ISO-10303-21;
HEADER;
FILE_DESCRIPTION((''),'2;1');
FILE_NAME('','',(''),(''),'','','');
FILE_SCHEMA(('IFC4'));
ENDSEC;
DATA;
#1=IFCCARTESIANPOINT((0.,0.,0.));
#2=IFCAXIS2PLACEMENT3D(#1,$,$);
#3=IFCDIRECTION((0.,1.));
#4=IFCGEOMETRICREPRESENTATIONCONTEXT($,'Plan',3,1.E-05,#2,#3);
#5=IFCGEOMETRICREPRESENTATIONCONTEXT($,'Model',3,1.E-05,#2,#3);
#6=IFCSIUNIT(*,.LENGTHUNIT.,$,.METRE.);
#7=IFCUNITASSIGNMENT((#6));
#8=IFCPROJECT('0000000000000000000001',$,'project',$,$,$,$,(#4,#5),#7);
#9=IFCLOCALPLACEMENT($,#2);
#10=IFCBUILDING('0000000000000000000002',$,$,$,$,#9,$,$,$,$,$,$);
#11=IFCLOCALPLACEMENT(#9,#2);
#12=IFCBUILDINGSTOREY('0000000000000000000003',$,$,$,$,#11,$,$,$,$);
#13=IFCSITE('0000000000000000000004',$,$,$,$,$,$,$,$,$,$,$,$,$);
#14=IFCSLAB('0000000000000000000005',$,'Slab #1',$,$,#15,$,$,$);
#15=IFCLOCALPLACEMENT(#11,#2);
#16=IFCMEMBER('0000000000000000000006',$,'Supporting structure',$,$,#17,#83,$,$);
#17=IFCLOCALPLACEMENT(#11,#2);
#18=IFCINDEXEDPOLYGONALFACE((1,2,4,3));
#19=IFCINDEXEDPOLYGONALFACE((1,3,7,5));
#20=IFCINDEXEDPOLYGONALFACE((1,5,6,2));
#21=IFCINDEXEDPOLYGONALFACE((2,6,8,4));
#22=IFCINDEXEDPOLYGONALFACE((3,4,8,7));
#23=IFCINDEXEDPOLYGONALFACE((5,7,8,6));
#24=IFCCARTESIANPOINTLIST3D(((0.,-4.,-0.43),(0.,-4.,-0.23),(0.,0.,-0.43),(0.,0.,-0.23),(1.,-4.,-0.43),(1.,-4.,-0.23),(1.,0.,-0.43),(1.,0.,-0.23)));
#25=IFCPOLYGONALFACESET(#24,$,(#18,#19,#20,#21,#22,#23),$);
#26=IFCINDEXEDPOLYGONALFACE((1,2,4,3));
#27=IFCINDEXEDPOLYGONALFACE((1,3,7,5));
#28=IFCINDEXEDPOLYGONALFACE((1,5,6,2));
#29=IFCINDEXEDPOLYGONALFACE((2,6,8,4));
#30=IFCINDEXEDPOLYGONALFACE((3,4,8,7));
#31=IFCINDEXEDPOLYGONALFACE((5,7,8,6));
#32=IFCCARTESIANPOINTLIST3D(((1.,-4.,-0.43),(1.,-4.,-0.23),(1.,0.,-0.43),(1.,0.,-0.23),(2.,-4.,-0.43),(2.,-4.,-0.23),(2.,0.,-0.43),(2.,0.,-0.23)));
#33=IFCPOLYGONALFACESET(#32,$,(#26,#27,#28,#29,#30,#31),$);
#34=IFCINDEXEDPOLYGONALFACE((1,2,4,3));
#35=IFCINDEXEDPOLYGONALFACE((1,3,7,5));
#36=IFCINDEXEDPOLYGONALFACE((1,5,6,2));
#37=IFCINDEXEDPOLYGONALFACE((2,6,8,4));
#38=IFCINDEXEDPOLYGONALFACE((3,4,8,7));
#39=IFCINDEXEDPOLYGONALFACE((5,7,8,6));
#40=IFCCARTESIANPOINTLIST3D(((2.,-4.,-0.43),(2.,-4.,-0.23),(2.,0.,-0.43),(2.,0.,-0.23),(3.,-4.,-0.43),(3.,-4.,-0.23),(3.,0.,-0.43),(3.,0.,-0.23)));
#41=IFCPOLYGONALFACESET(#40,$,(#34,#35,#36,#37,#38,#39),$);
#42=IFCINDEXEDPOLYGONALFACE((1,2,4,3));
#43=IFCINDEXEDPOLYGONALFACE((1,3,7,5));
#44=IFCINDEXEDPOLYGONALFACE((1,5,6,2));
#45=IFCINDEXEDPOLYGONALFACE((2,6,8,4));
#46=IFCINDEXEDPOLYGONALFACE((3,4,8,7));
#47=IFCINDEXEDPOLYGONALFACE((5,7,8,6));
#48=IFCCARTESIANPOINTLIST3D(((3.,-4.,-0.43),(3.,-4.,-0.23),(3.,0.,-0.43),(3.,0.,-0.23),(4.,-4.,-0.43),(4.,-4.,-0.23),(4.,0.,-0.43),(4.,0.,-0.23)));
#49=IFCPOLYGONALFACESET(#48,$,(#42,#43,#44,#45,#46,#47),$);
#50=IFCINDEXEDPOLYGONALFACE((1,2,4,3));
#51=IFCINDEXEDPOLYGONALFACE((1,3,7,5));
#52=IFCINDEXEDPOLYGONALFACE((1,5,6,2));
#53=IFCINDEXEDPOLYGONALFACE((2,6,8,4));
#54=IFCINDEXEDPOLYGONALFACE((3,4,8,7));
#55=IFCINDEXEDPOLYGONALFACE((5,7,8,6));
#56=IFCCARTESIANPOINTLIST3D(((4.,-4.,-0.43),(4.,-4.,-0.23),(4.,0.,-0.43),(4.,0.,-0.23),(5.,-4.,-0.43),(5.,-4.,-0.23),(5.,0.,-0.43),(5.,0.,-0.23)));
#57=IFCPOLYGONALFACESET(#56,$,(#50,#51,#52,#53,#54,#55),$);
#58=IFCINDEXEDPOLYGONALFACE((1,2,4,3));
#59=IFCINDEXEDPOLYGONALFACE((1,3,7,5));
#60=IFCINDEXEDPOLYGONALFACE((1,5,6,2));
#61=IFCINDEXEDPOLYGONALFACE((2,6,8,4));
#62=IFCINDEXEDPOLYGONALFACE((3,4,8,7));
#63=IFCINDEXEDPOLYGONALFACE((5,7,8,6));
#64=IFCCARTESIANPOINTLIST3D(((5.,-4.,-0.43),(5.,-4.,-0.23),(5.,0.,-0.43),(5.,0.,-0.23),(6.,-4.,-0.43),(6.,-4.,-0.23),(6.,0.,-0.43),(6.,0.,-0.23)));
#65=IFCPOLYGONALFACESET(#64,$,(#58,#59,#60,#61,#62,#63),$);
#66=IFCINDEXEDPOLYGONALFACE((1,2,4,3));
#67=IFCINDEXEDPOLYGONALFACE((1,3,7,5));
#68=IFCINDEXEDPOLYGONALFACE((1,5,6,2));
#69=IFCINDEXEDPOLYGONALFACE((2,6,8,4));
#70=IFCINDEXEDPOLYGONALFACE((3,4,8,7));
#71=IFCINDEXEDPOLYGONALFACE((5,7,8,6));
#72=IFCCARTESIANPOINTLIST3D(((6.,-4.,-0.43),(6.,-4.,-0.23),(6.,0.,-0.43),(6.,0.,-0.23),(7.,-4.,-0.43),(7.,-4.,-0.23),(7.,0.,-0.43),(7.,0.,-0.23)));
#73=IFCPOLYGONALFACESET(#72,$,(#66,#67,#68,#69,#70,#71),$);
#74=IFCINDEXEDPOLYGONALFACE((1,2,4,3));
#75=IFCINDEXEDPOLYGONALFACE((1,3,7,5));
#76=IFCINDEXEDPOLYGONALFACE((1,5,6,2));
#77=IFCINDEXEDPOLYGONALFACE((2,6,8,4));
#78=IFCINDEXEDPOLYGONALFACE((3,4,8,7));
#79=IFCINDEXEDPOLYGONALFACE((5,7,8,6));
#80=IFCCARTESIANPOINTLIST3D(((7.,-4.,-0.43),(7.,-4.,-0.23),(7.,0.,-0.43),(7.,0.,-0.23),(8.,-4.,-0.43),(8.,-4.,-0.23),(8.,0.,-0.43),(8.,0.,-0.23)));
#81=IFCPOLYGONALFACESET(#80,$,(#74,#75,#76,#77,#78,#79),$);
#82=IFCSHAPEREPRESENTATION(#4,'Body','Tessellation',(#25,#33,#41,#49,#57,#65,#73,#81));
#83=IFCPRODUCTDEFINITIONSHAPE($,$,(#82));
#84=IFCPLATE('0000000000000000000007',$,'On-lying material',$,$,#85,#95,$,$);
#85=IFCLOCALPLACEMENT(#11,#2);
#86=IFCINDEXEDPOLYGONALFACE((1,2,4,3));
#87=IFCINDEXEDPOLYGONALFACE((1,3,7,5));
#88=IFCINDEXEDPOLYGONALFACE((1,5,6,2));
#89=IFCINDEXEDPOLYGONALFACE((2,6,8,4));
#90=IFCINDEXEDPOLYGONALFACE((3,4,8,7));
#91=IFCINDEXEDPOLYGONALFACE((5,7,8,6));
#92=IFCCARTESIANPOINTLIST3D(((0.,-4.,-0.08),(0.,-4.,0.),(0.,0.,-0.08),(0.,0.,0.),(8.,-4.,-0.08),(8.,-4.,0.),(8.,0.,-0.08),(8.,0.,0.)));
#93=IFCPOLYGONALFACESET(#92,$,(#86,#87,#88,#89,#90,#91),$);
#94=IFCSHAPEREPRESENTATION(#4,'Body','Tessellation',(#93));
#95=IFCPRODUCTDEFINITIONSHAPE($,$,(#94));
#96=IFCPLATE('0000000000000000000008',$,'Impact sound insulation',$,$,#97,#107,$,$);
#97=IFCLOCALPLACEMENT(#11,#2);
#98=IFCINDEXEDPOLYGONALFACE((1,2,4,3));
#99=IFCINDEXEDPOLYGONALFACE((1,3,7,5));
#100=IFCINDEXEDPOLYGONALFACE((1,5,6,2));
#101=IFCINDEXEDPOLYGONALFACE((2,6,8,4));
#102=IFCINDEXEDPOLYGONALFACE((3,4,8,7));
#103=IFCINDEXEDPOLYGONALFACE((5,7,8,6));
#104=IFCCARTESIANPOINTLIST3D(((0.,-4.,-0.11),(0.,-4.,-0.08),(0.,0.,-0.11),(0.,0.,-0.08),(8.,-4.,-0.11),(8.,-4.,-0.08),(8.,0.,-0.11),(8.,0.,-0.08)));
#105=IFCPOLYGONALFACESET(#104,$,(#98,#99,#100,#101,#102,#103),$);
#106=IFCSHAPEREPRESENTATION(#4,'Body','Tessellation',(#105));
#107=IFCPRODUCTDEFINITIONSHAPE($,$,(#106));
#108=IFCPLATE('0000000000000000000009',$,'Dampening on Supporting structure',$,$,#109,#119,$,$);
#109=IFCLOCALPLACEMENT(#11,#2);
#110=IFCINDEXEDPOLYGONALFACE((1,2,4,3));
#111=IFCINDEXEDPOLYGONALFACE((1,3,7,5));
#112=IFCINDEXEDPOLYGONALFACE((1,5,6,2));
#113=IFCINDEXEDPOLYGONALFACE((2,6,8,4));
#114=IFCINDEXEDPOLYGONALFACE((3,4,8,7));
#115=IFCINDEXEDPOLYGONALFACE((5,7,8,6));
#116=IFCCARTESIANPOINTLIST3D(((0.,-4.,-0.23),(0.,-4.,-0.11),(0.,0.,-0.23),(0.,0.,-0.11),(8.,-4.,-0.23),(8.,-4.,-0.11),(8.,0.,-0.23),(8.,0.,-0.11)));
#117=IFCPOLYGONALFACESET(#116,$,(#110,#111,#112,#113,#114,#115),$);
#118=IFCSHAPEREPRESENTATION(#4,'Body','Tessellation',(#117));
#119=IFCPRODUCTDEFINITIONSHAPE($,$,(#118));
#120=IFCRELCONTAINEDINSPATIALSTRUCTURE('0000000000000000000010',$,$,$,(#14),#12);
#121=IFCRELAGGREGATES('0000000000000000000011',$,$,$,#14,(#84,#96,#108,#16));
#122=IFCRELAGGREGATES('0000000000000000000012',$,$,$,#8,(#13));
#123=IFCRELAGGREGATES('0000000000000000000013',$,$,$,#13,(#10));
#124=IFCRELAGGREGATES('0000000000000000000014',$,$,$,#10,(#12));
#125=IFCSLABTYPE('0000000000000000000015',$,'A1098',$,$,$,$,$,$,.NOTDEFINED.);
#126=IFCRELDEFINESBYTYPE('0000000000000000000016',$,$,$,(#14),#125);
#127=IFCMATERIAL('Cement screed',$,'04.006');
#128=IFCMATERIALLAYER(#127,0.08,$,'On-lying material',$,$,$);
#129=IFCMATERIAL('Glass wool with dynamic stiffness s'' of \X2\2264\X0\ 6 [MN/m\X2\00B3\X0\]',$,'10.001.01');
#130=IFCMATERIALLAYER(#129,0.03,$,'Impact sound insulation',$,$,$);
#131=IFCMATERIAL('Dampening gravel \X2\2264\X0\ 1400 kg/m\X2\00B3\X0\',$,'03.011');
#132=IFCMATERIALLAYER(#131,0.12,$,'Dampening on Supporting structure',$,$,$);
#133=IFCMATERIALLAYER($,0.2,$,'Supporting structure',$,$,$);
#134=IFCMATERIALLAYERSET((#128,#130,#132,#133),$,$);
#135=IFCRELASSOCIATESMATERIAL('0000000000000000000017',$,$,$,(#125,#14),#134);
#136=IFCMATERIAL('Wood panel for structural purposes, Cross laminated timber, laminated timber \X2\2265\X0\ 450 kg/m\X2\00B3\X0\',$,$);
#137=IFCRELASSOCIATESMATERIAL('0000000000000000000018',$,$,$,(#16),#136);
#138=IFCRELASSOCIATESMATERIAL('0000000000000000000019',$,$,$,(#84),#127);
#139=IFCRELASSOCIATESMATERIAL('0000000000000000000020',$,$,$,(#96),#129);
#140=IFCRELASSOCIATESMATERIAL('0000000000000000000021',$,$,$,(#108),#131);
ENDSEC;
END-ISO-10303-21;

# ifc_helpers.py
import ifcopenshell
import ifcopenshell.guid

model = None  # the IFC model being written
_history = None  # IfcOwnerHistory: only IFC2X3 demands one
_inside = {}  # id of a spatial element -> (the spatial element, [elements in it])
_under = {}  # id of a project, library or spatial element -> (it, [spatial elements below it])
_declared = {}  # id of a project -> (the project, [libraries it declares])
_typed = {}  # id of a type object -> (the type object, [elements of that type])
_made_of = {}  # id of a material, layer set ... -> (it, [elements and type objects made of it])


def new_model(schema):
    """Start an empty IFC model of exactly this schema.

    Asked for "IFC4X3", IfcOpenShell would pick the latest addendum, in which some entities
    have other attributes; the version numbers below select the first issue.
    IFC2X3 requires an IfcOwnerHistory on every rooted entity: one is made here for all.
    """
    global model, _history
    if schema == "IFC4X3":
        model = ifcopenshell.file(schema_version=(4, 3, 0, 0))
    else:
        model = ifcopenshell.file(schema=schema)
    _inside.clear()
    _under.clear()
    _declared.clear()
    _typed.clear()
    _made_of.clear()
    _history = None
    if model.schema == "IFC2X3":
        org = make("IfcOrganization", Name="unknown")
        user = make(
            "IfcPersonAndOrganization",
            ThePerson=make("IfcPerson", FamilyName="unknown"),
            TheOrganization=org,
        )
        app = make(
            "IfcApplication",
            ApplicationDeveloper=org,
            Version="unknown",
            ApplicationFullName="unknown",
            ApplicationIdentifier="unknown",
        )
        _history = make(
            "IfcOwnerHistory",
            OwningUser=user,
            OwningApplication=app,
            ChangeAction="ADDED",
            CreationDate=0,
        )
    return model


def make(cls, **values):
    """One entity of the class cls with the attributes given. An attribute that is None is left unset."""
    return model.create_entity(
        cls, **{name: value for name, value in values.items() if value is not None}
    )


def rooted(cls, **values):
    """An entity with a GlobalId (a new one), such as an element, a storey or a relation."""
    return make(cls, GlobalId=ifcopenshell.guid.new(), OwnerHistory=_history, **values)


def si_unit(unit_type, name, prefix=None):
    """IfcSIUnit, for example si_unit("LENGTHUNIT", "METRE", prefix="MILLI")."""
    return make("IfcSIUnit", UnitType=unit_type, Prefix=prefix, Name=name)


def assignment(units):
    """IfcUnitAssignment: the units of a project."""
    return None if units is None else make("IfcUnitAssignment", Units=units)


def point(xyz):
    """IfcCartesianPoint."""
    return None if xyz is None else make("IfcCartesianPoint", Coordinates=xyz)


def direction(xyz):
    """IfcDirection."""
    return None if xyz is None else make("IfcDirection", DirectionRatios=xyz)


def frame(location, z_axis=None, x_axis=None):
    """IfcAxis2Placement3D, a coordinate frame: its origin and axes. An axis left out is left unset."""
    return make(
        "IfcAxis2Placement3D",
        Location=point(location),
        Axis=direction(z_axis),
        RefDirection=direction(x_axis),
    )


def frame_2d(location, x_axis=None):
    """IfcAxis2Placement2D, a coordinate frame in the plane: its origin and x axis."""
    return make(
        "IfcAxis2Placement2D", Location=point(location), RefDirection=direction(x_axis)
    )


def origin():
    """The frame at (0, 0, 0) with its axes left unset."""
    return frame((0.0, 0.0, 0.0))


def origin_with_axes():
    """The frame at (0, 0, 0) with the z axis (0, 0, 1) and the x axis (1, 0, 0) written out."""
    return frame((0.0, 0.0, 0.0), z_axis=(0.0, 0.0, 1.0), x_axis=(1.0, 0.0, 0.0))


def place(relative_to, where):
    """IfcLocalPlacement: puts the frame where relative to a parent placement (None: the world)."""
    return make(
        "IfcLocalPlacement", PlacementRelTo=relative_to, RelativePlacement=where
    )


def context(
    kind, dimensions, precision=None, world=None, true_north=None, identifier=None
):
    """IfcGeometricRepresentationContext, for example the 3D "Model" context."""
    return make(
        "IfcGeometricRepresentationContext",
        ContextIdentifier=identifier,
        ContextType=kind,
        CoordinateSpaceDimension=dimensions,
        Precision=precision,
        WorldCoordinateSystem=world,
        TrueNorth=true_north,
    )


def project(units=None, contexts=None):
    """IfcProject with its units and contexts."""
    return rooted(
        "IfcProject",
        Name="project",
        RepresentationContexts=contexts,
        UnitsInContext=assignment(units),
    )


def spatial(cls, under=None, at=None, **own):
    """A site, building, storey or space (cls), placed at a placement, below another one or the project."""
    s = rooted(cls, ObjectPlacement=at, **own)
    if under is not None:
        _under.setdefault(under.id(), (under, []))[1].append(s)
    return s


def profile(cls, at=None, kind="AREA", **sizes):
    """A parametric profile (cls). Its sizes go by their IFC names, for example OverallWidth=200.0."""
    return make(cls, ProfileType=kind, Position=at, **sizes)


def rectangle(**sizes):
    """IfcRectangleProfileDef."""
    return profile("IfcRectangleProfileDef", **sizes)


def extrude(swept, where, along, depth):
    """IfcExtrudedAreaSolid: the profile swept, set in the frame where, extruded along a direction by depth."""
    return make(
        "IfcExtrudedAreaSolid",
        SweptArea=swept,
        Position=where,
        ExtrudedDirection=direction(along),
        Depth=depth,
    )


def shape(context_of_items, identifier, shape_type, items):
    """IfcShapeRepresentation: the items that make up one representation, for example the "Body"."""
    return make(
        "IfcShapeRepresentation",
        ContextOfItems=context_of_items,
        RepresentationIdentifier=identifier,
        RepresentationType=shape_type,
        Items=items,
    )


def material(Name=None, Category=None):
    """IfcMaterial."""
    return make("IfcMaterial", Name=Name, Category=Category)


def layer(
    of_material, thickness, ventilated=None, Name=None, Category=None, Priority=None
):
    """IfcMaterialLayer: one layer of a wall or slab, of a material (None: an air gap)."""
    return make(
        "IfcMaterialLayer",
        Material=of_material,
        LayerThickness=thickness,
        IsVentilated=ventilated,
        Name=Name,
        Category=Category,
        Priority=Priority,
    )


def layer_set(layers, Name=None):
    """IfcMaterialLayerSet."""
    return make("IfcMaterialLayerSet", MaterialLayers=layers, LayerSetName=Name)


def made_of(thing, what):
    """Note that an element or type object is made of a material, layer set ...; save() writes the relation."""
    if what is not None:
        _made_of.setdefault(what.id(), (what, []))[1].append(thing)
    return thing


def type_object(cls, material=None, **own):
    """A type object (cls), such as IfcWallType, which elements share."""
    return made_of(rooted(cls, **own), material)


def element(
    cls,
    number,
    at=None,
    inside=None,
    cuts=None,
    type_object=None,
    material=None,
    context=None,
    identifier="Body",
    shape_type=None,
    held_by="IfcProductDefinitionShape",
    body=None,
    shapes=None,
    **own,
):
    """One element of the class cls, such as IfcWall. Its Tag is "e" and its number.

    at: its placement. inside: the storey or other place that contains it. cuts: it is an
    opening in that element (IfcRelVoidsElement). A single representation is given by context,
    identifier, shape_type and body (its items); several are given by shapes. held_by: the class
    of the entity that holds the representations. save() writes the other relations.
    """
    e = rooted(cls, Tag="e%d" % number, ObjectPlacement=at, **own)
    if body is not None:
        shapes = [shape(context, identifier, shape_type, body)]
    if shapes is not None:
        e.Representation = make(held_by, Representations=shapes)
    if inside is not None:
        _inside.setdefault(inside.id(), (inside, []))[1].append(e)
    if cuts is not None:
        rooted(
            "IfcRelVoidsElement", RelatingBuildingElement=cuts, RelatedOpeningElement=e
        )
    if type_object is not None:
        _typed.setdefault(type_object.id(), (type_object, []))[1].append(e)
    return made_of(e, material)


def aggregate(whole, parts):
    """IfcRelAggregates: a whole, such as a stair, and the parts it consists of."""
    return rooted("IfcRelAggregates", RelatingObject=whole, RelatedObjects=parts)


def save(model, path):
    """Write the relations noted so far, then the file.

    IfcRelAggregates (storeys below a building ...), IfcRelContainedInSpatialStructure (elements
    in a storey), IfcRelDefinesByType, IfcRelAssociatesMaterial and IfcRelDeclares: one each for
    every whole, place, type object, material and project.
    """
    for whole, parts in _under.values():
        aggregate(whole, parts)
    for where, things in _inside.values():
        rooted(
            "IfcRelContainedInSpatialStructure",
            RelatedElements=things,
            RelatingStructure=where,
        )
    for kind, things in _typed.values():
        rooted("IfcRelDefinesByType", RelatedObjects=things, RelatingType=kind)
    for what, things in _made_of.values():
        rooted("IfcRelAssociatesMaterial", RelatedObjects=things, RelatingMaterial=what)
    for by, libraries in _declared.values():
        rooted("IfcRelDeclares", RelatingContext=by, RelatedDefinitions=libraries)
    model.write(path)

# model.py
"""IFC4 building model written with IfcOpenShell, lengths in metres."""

from ifc_helpers import new_model, si_unit, direction, frame, frame_2d, origin, origin_with_axes, place, context, project, spatial, rectangle, extrude, material, layer, layer_set, type_object, element, aggregate, save


model = new_model("IFC4")

# Units and contexts
plan_context = context("Plan", 3, precision=1e-05, world=origin(), true_north=direction((0.0, 1.0)))
model_context = context("Model", 3, precision=1e-05, world=origin(), true_north=direction((0.0, 1.0)))
ifc_project = project(units=[si_unit("LENGTHUNIT", "METRE")], contexts=[plan_context, model_context])

# Site, building, storey
site = spatial("IfcSite", under=ifc_project)
building_placement = place(None, origin())
building = spatial("IfcBuilding", under=site, at=building_placement)
storey_placement = place(building_placement, origin())
storey = spatial("IfcBuildingStorey", under=building, at=storey_placement)

# Slab, member, plates
ifc_material_1 = material(Name="Cement screed", Category="04.006")
ifc_layer_1 = layer(ifc_material_1, 0.08, Name="On-lying material")
ifc_material_2 = material(Name="Glass wool with dynamic stiffness s' of ≤ 6 [MN/m³]", Category="10.001.01")
ifc_layer_2 = layer(ifc_material_2, 0.03, Name="Impact sound insulation")
ifc_material_3 = material(Name="Dampening gravel ≤ 1400 kg/m³", Category="03.011")
ifc_layer_3 = layer(ifc_material_3, 0.12, Name="Dampening on Supporting structure")
ifc_layer_4 = layer(None, 0.2, Name="Supporting structure")
ifc_layer_set = layer_set([ifc_layer_1, ifc_layer_2, ifc_layer_3, ifc_layer_4])
slab_type = type_object("IfcSlabType", Name="A1098", PredefinedType="NOTDEFINED", material=ifc_layer_set)
slab_placement = place(None, frame((0.0, 0.0, 0.0), z_axis=(0.0, 0.0, -1.0), x_axis=(1.0, 0.0, 0.0)))
slab = element("IfcSlab", 1, at=slab_placement, inside=storey, type_object=slab_type, material=ifc_layer_set, Name="Slab #1")
ifc_material_4 = material(Name="Wood panel for structural purposes, Cross laminated timber, laminated timber ≥ 450 kg/m³")
member_placement = place(slab_placement, origin())
member = element("IfcMember", 2, at=member_placement, material=ifc_material_4, Name="Supporting structure", context=plan_context, shape_type="SweptSolid", body=[
    extrude(rectangle(XDim=1.0, YDim=0.2, at=frame_2d((0.5, 0.1), x_axis=(1.0, 0.0))), frame((0.0, 4.0, 0.23), z_axis=(0.0, -1.0, 0.0), x_axis=(1.0, 0.0, 0.0)), (0.0, 0.0, 1.0), 4.0),
    extrude(rectangle(XDim=1.0, YDim=0.2, at=frame_2d((0.5, 0.1), x_axis=(1.0, 0.0))), frame((1.0, 4.0, 0.23), z_axis=(0.0, -1.0, 0.0), x_axis=(1.0, 0.0, 0.0)), (0.0, 0.0, 1.0), 4.0),
    extrude(rectangle(XDim=1.0, YDim=0.2, at=frame_2d((0.5, 0.1), x_axis=(1.0, 0.0))), frame((2.0, 4.0, 0.23), z_axis=(0.0, -1.0, 0.0), x_axis=(1.0, 0.0, 0.0)), (0.0, 0.0, 1.0), 4.0),
    extrude(rectangle(XDim=1.0, YDim=0.2, at=frame_2d((0.5, 0.1), x_axis=(1.0, 0.0))), frame((3.0, 4.0, 0.23), z_axis=(0.0, -1.0, 0.0), x_axis=(1.0, 0.0, 0.0)), (0.0, 0.0, 1.0), 4.0),
    extrude(rectangle(XDim=1.0, YDim=0.2, at=frame_2d((0.5, 0.1), x_axis=(1.0, 0.0))), frame((4.0, 4.0, 0.23), z_axis=(0.0, -1.0, 0.0), x_axis=(1.0, 0.0, 0.0)), (0.0, 0.0, 1.0), 4.0),
    extrude(rectangle(XDim=1.0, YDim=0.2, at=frame_2d((0.5, 0.1), x_axis=(1.0, 0.0))), frame((5.0, 4.0, 0.23), z_axis=(0.0, -1.0, 0.0), x_axis=(1.0, 0.0, 0.0)), (0.0, 0.0, 1.0), 4.0),
    extrude(rectangle(XDim=1.0, YDim=0.2, at=frame_2d((0.5, 0.1), x_axis=(1.0, 0.0))), frame((6.0, 4.0, 0.23), z_axis=(0.0, -1.0, 0.0), x_axis=(1.0, 0.0, 0.0)), (0.0, 0.0, 1.0), 4.0),
    extrude(rectangle(XDim=1.0, YDim=0.2, at=frame_2d((0.5, 0.1), x_axis=(1.0, 0.0))), frame((7.0, 4.0, 0.23), z_axis=(0.0, -1.0, 0.0), x_axis=(1.0, 0.0, 0.0)), (0.0, 0.0, 1.0), 4.0),
])
plate_1_placement = place(slab_placement, origin())
plate_1 = element("IfcPlate", 3, at=plate_1_placement, material=ifc_material_1, Name="On-lying material", context=plan_context, shape_type="SweptSolid", body=[
    extrude(rectangle(XDim=8.0, YDim=4.0, at=frame_2d((4.0, 2.0), x_axis=(1.0, 0.0))), origin_with_axes(), (0.0, 0.0, 1.0), 0.08),
])
plate_2_placement = place(slab_placement, origin())
plate_2 = element("IfcPlate", 4, at=plate_2_placement, material=ifc_material_2, Name="Impact sound insulation", context=plan_context, shape_type="SweptSolid", body=[
    extrude(rectangle(XDim=8.0, YDim=4.0, at=frame_2d((4.0, 2.0), x_axis=(1.0, 0.0))), frame((0.0, 0.0, 0.08), z_axis=(0.0, 0.0, 1.0), x_axis=(1.0, 0.0, 0.0)), (0.0, 0.0, 1.0), 0.03),
])
plate_3_placement = place(slab_placement, origin())
plate_3 = element("IfcPlate", 5, at=plate_3_placement, material=ifc_material_3, Name="Dampening on Supporting structure", context=plan_context, shape_type="SweptSolid", body=[
    extrude(rectangle(XDim=8.0, YDim=4.0, at=frame_2d((4.0, 2.0), x_axis=(1.0, 0.0))), frame((0.0, 0.0, 0.11), z_axis=(0.0, 0.0, 1.0), x_axis=(1.0, 0.0, 0.0)), (0.0, 0.0, 1.0), 0.12),
])
aggregate(slab, [plate_1, plate_2, plate_3, member])

save(model, "model.ifc")
